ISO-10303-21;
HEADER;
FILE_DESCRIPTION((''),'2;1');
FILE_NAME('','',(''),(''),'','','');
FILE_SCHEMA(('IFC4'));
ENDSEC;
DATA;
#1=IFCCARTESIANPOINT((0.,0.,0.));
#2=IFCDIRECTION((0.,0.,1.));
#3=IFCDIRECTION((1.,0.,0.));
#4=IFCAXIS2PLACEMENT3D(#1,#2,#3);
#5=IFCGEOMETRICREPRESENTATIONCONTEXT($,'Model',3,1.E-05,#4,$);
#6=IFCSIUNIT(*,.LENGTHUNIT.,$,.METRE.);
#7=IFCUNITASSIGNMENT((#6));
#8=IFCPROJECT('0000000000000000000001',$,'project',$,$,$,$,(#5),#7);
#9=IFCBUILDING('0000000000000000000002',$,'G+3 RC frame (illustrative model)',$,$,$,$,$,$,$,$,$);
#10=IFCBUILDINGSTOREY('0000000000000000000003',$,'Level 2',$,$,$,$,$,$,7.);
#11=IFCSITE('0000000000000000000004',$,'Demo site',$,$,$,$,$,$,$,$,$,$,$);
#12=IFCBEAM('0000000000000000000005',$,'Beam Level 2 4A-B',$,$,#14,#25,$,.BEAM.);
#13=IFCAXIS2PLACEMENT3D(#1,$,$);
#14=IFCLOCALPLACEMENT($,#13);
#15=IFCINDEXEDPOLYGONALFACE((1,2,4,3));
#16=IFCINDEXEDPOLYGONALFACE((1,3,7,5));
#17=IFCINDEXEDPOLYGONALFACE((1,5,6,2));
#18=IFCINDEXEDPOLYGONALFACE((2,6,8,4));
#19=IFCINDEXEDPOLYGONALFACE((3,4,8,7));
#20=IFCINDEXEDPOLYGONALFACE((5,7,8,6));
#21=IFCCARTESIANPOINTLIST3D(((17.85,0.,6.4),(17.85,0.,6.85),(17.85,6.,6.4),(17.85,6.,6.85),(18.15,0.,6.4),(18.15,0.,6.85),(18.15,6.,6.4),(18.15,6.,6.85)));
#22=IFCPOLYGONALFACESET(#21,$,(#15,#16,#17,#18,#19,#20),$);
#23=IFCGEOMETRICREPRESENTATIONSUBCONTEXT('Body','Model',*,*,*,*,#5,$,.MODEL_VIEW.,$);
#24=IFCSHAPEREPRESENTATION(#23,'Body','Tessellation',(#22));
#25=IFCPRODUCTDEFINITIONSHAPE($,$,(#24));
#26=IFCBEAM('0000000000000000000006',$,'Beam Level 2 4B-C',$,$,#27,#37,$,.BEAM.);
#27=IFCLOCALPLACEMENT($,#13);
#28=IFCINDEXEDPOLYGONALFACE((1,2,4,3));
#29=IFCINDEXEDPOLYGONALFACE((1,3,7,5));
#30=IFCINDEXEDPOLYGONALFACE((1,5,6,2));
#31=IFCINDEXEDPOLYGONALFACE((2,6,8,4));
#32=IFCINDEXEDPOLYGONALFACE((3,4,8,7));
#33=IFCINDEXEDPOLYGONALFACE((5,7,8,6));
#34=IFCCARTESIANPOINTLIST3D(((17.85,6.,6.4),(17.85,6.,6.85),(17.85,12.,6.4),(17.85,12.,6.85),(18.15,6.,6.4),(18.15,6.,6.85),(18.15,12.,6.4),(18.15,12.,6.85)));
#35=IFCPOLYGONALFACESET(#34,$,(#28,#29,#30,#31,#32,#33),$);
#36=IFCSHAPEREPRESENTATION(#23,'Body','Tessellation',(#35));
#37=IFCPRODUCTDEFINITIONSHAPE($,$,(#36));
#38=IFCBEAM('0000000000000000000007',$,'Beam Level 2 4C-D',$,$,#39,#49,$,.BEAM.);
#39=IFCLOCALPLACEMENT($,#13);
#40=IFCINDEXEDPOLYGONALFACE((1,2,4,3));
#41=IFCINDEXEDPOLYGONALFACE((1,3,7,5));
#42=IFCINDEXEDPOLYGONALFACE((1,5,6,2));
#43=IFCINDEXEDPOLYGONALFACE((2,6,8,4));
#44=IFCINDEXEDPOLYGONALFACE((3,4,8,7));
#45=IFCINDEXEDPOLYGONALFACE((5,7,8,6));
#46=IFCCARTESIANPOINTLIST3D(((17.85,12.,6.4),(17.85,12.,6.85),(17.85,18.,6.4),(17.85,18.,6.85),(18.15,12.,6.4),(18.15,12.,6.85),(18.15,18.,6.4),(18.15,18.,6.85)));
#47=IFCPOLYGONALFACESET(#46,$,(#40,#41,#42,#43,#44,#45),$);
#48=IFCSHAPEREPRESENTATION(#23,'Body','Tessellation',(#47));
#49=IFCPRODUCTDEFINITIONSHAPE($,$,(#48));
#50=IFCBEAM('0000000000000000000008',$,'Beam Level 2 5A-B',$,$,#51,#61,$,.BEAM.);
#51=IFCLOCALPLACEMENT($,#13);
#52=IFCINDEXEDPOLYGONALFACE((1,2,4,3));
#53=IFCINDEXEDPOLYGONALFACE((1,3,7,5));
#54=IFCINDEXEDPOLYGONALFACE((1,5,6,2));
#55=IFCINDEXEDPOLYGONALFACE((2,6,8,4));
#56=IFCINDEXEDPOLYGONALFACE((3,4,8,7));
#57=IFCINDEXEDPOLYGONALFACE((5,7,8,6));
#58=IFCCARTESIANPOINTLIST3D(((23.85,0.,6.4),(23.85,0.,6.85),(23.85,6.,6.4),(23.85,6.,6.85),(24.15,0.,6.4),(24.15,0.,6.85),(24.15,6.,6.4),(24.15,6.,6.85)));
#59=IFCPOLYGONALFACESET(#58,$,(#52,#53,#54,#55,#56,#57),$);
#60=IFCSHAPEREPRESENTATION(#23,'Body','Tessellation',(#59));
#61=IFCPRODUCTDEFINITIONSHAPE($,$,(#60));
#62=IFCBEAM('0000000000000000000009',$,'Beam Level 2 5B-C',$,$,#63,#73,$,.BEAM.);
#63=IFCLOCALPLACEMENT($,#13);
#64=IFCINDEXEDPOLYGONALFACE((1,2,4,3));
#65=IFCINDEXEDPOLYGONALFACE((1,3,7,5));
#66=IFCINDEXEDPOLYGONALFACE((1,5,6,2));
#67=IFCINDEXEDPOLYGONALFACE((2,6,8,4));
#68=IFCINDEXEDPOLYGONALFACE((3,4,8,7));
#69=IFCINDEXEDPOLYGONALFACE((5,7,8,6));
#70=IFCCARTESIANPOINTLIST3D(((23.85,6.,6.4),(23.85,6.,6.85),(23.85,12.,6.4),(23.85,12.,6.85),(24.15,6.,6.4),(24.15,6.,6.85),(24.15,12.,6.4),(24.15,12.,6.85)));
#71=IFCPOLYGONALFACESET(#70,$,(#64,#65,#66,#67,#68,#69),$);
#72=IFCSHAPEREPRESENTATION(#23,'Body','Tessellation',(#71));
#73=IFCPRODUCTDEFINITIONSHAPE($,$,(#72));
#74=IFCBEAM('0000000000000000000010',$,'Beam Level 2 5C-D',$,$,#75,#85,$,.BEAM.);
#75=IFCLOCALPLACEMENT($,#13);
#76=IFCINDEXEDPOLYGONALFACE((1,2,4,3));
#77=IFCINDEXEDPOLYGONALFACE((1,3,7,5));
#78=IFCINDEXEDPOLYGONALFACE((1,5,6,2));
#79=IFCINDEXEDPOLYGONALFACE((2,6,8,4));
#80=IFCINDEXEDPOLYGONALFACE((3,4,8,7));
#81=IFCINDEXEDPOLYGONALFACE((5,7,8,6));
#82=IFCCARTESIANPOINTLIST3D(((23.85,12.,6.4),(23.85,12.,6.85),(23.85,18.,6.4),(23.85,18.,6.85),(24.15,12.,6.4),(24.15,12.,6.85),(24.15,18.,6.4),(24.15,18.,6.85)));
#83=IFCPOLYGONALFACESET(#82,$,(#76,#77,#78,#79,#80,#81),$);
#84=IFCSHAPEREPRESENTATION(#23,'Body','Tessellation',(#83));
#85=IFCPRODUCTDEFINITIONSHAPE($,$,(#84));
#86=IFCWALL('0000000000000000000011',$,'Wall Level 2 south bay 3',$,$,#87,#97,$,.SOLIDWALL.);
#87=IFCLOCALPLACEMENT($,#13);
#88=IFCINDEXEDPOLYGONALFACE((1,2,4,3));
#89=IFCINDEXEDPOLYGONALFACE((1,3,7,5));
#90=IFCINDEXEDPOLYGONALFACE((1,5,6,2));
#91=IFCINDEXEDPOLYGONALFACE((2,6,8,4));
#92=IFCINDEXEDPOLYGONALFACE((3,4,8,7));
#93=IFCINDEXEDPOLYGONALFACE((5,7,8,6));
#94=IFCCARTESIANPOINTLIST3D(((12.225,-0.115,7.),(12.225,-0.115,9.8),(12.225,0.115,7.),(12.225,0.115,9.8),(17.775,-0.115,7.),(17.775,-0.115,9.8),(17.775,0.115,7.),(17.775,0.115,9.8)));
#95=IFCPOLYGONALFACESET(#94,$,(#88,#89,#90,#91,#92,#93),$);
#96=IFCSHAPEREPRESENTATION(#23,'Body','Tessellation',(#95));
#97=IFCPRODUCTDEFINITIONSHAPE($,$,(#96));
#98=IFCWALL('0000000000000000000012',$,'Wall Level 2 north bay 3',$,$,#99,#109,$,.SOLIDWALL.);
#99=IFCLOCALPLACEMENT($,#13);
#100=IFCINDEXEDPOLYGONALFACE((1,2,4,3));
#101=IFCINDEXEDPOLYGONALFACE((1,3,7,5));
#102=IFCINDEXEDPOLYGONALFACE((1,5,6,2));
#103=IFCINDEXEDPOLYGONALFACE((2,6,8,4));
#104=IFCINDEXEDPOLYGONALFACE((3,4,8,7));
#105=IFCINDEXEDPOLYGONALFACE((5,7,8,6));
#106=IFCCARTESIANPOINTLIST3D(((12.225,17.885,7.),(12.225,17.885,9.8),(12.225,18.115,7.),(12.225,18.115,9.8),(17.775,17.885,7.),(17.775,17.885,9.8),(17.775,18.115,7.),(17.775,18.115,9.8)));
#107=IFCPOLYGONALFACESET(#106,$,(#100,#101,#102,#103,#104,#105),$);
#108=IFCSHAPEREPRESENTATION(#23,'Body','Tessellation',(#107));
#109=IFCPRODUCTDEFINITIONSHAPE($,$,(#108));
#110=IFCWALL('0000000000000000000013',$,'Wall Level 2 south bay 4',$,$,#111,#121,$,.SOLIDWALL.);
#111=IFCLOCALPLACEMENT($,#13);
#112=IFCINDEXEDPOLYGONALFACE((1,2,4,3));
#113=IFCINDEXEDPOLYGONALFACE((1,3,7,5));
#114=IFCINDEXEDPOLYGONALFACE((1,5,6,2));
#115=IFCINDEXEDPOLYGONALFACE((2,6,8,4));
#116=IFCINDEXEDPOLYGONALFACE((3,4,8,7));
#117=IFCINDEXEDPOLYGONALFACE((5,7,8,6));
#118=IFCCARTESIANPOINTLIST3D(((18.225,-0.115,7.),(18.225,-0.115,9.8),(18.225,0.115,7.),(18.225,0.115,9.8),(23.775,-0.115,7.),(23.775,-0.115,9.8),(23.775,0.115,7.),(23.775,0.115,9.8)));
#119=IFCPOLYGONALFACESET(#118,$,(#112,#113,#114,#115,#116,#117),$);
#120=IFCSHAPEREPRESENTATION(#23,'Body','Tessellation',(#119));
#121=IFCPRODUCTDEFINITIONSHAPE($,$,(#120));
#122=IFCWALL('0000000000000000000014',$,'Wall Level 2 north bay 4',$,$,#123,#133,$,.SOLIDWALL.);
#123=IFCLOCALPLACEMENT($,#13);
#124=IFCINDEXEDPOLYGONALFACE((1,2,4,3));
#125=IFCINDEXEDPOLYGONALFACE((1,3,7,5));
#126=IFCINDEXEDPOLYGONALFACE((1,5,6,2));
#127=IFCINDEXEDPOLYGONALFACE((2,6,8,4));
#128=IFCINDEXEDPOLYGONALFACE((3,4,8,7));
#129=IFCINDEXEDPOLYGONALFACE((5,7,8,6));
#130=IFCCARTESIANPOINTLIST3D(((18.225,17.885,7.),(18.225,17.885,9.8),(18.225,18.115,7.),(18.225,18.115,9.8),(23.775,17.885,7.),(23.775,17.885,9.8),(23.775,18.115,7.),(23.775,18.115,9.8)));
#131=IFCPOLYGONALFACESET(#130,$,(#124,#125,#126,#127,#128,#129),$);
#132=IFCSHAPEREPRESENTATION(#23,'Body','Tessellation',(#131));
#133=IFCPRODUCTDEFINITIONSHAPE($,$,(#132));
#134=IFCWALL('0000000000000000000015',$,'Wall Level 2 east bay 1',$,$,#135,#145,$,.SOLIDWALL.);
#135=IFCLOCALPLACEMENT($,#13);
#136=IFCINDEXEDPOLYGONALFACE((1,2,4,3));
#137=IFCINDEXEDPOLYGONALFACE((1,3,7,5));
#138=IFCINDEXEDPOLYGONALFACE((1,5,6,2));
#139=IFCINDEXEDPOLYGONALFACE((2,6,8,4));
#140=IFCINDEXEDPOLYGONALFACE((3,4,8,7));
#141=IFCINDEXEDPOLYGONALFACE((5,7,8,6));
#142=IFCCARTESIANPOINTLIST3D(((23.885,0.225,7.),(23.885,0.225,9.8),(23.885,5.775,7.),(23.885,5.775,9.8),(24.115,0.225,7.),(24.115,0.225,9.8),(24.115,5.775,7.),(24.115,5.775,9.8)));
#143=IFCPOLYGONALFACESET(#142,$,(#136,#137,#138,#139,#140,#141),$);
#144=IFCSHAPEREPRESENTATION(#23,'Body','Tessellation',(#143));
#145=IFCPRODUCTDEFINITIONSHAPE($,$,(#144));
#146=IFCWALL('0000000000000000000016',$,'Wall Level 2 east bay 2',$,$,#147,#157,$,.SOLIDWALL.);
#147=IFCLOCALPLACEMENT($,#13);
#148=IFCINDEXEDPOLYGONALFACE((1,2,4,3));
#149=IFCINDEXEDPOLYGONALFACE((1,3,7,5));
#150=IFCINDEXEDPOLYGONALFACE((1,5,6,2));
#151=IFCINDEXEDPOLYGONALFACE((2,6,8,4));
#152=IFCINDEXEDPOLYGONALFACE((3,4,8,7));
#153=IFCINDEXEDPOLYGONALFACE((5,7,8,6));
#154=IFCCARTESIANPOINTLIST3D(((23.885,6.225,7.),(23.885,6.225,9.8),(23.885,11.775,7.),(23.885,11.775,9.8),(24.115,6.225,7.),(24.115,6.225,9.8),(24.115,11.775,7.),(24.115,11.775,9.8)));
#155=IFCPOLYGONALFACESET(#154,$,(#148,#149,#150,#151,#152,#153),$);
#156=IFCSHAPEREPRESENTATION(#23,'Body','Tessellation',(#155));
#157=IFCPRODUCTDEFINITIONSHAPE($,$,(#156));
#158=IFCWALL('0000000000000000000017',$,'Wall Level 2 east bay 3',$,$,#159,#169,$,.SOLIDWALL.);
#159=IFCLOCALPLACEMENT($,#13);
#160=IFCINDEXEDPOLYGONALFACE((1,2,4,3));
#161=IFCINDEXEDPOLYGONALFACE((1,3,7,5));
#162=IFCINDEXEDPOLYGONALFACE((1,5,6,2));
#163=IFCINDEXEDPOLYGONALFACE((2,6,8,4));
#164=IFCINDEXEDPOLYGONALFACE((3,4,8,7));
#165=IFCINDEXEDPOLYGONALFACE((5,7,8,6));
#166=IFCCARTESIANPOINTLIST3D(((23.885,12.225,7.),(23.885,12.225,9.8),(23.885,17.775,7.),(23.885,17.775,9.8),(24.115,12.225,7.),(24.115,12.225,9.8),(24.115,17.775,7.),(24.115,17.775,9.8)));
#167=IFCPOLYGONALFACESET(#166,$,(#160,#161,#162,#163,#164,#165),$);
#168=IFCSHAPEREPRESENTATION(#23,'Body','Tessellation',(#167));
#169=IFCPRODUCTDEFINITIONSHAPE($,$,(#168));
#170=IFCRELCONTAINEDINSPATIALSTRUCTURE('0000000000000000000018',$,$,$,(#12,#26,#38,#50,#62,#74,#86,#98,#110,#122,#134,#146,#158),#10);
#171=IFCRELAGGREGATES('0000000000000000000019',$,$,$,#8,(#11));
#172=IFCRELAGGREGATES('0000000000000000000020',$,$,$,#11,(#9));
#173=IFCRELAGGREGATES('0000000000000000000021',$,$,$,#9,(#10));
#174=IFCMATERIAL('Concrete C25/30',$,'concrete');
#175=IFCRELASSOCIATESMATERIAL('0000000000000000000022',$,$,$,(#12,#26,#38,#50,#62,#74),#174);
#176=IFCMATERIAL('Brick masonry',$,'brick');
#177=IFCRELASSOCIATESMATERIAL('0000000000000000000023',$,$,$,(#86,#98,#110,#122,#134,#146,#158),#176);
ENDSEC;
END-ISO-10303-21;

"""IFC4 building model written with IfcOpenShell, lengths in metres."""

from ifc_helpers import new_model, si_unit, frame, frame_2d, origin, origin_with_axes, place, context, subcontext, project, spatial, rectangle, extrude, material, element, save


model = new_model("IFC4")

# Units and contexts
model_context = context("Model", 3, precision=1e-05, world=origin_with_axes())
body_context = subcontext(model_context, "Body", "Model", "MODEL_VIEW")
ifc_project = project(units=[si_unit("LENGTHUNIT", "METRE")], contexts=[model_context])

# Site, building, storey
site = spatial("IfcSite", under=ifc_project, Name="Demo site")
building = spatial("IfcBuilding", under=site, Name="G+3 RC frame (illustrative model)")
storey = spatial("IfcBuildingStorey", under=building, Name="Level 2", Elevation=7.0)

# Shared definitions
ifc_material_1 = material(Name="Concrete C25/30", Category="concrete")

# Beams
for number, where, z_axis, x_axis, name in (
    (1, (17.85, 0.0, 6.4), (0.0, 0.0, 1.0), (1.0, 0.0, 0.0), "Beam Level 2 4A-B"),
    (2, (17.85, 6.0, 6.4), (0.0, 0.0, 1.0), (1.0, 0.0, 0.0), "Beam Level 2 4B-C"),
    (3, (17.85, 12.0, 6.4), (0.0, 0.0, 1.0), (1.0, 0.0, 0.0), "Beam Level 2 4C-D"),
    (4, (23.85, 0.0, 6.4), (0.0, 0.0, 1.0), (1.0, 0.0, 0.0), "Beam Level 2 5A-B"),
    (5, (23.85, 6.0, 6.4), (0.0, 0.0, 1.0), (1.0, 0.0, 0.0), "Beam Level 2 5B-C"),
    (6, (23.85, 12.0, 6.4), (0.0, 0.0, 1.0), (1.0, 0.0, 0.0), "Beam Level 2 5C-D"),
):
    element("IfcBeam", number, at=place(None, frame(where, z_axis=z_axis, x_axis=x_axis)), inside=storey, material=ifc_material_1, Name=name, PredefinedType="BEAM", context=body_context, shape_type="SweptSolid", body=[
        extrude(rectangle(XDim=0.3, YDim=6.0, at=frame_2d((0.15, 3.0))), origin(), (0.0, 0.0, 1.0), 0.45),
    ])

# Walls
ifc_material_2 = material(Name="Brick masonry", Category="brick")
for number, where, z_axis, x_axis, name in (
    (7, (12.225, -0.115, 7.0), (0.0, 0.0, 1.0), (1.0, 0.0, 0.0), "Wall Level 2 south bay 3"),
    (8, (12.225, 17.885, 7.0), (0.0, 0.0, 1.0), (1.0, 0.0, 0.0), "Wall Level 2 north bay 3"),
    (9, (18.225, -0.115, 7.0), (0.0, 0.0, 1.0), (1.0, 0.0, 0.0), "Wall Level 2 south bay 4"),
    (10, (18.225, 17.885, 7.0), (0.0, 0.0, 1.0), (1.0, 0.0, 0.0), "Wall Level 2 north bay 4"),
):
    element("IfcWall", number, at=place(None, frame(where, z_axis=z_axis, x_axis=x_axis)), inside=storey, material=ifc_material_2, Name=name, PredefinedType="SOLIDWALL", context=body_context, shape_type="SweptSolid", body=[
        extrude(rectangle(XDim=5.55, YDim=0.23, at=frame_2d((2.775, 0.115))), origin(), (0.0, 0.0, 1.0), 2.8),
    ])
for number, where, z_axis, x_axis, name in (
    (11, (23.885, 0.225, 7.0), (0.0, 0.0, 1.0), (1.0, 0.0, 0.0), "Wall Level 2 east bay 1"),
    (12, (23.885, 6.225, 7.0), (0.0, 0.0, 1.0), (1.0, 0.0, 0.0), "Wall Level 2 east bay 2"),
    (13, (23.885, 12.225, 7.0), (0.0, 0.0, 1.0), (1.0, 0.0, 0.0), "Wall Level 2 east bay 3"),
):
    element("IfcWall", number, at=place(None, frame(where, z_axis=z_axis, x_axis=x_axis)), inside=storey, material=ifc_material_2, Name=name, PredefinedType="SOLIDWALL", context=body_context, shape_type="SweptSolid", body=[
        extrude(rectangle(XDim=0.23, YDim=5.55, at=frame_2d((0.115, 2.775))), origin(), (0.0, 0.0, 1.0), 2.8),
    ])

save(model, "model.ifc")
